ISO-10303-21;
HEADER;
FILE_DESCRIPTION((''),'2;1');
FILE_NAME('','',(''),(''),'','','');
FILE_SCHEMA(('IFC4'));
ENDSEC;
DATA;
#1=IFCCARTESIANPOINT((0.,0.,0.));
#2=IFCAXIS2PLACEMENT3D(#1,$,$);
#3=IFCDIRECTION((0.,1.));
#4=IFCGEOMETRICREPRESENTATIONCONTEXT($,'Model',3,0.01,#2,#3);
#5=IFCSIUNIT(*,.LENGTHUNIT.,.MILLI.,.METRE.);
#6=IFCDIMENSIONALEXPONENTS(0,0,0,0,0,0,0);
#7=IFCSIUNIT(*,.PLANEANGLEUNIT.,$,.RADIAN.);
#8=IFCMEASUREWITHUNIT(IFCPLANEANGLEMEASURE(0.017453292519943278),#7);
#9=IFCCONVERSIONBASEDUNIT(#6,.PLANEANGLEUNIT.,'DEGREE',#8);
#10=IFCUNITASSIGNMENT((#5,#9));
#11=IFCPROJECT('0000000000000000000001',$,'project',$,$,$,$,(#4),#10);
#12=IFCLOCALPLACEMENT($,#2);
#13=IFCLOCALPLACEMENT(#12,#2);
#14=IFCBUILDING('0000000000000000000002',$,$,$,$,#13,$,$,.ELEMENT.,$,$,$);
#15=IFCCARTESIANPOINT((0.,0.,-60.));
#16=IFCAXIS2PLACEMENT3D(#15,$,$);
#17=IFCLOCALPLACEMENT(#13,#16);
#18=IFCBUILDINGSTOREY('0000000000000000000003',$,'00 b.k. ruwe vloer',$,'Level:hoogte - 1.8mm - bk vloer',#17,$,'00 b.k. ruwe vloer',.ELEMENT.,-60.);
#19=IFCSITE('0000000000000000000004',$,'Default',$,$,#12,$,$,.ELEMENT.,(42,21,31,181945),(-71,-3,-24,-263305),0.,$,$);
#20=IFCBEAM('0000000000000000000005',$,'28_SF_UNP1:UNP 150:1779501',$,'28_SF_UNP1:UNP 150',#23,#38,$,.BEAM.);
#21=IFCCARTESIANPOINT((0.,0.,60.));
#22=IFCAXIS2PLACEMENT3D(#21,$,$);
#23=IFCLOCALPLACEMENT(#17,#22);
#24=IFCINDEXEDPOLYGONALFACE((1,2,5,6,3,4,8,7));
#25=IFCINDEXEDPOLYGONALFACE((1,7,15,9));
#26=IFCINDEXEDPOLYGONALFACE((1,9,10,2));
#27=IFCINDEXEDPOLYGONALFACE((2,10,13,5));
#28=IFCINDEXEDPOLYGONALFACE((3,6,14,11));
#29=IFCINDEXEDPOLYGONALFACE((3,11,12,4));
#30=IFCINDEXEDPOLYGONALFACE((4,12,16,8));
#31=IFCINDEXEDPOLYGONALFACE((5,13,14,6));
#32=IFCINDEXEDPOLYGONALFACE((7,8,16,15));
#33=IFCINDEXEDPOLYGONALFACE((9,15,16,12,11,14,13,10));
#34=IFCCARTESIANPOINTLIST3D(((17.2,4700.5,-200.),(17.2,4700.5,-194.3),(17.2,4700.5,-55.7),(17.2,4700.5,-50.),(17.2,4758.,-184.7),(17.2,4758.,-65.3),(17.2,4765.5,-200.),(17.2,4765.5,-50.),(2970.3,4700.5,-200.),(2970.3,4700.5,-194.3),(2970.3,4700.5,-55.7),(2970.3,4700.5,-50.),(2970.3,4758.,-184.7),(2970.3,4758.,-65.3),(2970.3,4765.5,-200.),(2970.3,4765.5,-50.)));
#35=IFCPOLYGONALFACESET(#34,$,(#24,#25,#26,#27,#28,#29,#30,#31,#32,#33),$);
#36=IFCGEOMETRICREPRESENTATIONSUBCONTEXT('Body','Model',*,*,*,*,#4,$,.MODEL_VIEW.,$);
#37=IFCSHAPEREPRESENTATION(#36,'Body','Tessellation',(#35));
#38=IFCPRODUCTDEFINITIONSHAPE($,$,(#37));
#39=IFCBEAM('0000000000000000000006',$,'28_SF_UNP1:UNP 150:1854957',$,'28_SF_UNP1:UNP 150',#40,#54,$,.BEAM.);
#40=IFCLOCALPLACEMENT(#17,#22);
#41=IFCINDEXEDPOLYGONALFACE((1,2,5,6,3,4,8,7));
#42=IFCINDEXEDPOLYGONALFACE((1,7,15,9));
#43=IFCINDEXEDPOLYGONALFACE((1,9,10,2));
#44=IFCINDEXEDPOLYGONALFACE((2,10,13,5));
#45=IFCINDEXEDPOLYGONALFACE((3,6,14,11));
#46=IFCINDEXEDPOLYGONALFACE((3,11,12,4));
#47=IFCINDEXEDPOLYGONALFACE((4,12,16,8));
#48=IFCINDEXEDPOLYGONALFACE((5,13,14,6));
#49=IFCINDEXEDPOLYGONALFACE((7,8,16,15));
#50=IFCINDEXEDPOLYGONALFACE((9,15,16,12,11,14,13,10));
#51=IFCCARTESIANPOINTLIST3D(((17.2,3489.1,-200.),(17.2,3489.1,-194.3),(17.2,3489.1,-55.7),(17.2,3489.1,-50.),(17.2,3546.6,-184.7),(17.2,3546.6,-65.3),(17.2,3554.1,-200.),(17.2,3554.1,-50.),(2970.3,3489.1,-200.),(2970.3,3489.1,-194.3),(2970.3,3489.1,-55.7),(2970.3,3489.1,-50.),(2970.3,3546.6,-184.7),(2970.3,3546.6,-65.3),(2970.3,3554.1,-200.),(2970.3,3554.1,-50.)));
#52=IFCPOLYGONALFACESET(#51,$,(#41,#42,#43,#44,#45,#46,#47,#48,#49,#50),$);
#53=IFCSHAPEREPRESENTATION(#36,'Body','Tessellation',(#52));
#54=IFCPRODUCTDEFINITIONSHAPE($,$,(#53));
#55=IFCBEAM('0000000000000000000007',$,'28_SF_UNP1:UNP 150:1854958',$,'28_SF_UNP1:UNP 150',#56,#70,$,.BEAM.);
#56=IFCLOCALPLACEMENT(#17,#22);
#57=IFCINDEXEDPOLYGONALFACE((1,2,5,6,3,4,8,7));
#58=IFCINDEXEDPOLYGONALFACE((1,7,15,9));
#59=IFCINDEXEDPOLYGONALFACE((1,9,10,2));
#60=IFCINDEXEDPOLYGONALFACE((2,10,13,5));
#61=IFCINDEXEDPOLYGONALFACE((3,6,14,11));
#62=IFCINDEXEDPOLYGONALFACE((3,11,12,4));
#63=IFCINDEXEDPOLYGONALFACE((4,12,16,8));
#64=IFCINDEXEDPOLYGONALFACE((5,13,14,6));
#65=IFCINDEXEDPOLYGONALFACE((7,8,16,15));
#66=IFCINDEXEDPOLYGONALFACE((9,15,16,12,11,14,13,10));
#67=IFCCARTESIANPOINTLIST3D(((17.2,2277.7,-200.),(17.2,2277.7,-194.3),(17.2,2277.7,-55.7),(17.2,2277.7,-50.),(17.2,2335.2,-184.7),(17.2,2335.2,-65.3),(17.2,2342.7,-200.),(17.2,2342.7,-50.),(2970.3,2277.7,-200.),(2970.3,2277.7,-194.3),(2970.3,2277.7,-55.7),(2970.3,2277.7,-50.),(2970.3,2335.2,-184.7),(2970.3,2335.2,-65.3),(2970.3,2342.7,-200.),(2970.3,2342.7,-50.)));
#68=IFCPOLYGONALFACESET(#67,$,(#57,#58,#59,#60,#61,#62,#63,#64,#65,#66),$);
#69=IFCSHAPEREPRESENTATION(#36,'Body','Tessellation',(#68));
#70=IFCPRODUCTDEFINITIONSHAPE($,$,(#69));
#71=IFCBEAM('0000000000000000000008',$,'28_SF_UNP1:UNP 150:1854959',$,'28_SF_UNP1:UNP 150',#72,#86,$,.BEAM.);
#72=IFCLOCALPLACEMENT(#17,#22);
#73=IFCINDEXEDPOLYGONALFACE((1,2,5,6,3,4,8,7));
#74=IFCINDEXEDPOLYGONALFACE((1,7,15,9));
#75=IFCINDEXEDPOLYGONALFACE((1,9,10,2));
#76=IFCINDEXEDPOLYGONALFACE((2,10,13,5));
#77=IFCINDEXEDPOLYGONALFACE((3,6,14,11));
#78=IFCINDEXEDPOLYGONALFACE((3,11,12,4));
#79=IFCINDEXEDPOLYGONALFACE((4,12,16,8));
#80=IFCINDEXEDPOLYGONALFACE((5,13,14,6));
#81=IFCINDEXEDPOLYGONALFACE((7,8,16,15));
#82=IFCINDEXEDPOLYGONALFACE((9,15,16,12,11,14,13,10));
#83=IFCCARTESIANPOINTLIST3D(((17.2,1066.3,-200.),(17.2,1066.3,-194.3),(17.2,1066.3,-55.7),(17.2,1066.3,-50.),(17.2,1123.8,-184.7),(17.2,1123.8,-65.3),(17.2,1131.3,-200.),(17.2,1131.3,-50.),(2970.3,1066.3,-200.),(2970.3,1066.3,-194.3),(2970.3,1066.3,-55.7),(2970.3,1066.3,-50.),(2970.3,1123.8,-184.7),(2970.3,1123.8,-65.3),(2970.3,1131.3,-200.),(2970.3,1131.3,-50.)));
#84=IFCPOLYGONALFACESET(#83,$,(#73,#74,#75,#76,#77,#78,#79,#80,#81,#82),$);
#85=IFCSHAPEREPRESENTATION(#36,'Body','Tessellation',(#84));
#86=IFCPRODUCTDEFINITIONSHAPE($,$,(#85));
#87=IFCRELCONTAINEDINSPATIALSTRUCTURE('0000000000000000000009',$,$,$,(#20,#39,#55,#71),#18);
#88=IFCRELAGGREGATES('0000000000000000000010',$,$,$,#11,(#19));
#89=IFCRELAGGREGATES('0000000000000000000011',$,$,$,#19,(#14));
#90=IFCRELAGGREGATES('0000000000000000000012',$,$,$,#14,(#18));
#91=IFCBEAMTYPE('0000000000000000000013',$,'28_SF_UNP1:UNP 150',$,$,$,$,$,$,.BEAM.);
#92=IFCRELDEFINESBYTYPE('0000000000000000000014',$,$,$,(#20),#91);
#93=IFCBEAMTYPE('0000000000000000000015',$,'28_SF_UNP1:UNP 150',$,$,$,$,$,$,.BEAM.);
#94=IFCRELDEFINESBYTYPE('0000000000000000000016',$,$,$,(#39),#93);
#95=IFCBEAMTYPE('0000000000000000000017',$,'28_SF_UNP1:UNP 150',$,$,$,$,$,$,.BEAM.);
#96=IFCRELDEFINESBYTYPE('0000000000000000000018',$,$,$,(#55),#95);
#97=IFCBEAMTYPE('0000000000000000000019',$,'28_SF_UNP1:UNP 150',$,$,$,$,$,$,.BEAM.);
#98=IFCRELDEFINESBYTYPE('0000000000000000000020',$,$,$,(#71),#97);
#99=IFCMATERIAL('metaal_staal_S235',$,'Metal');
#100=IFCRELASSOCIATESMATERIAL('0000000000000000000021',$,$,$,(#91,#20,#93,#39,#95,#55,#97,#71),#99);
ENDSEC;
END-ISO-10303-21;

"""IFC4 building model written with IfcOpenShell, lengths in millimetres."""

from ifc_helpers import new_model, entity, si_unit, converted_unit, direction, frame, origin, place, context, subcontext, project, spatial, indexed_curve, outline, extrude, source, transform, mapped, material, type_object, type_shapes, element, save


model = new_model("IFC4")

# Units and contexts
model_context = context("Model", 3, precision=0.01, world=origin(), true_north=direction((0.0, 1.0)))
body_context = subcontext(model_context, "Body", "Model", "MODEL_VIEW")
ifc_project = project(units=[si_unit("LENGTHUNIT", "METRE", prefix="MILLI"), converted_unit("PLANEANGLEUNIT", "DEGREE", entity("IfcPlaneAngleMeasure", 0.017453292519943278), si_unit("PLANEANGLEUNIT", "RADIAN"), dimensions=[0, 0, 0, 0, 0, 0, 0])], contexts=[model_context])

# Site, building, storey
site_placement = place(None, origin())
site = spatial("IfcSite", under=ifc_project, at=site_placement, Name="Default", CompositionType="ELEMENT", RefLatitude=(42, 21, 31, 181945), RefLongitude=(-71, -3, -24, -263305), RefElevation=0.0)
building_placement = place(site_placement, origin())
building = spatial("IfcBuilding", under=site, at=building_placement, CompositionType="ELEMENT")
storey_placement = place(building_placement, frame((0.0, 0.0, -60.0)))
storey = spatial("IfcBuildingStorey", under=building, at=storey_placement, Name="00 b.k. ruwe vloer", ObjectType="Level:hoogte - 1.8mm - bk vloer", LongName="00 b.k. ruwe vloer", CompositionType="ELEMENT", Elevation=-60.0)

# Beams
ifc_material = material(Name="metaal_staal_S235", Category="Metal")
beam_type_1 = type_object("IfcBeamType", Name="28_SF_UNP1:UNP 150", PredefinedType="BEAM", material=ifc_material)
shared_shape_1 = source(origin(), body_context, "Body", "SweptSolid", [
    extrude(outline(indexed_curve([(-75.0, -30.6), (-69.3, -30.6), (-59.7, 26.9), (59.7, 26.9), (69.3, -30.6), (75.0, -30.6), (75.0, 34.4), (-75.0, 34.4), (-75.0, -30.6)], self_intersect=False)), frame((17.2, 4731.2, -125.0), z_axis=(1.0, 0.0, 0.0), x_axis=(0.0, 0.0, -1.0)), (0.0, 0.0, 1.0), 2953.2),
])
type_shapes(beam_type_1, [shared_shape_1])
beam_1_placement = place(storey_placement, frame((0.0, 0.0, 60.0)))
element("IfcBeam", 1, at=beam_1_placement, inside=storey, type_object=beam_type_1, material=ifc_material, Name="28_SF_UNP1:UNP 150:1779501", ObjectType="28_SF_UNP1:UNP 150", PredefinedType="BEAM", context=body_context, shape_type="MappedRepresentation", body=[
    mapped(shared_shape_1, transform((0.0, 0.0, 0.0), scale=1.0)),
])
beam_type_2 = type_object("IfcBeamType", Name="28_SF_UNP1:UNP 150", PredefinedType="BEAM", material=ifc_material)
shared_shape_2 = source(origin(), body_context, "Body", "SweptSolid", [
    extrude(outline(indexed_curve([(-75.0, -30.6), (-69.3, -30.6), (-59.7, 26.9), (59.7, 26.9), (69.3, -30.6), (75.0, -30.6), (75.0, 34.4), (-75.0, 34.4), (-75.0, -30.6)], self_intersect=False)), frame((17.2, 3519.8, -125.0), z_axis=(1.0, 0.0, 0.0), x_axis=(0.0, 0.0, -1.0)), (0.0, 0.0, 1.0), 2953.2),
])
type_shapes(beam_type_2, [shared_shape_2])
beam_2_placement = place(storey_placement, frame((0.0, 0.0, 60.0)))
element("IfcBeam", 2, at=beam_2_placement, inside=storey, type_object=beam_type_2, material=ifc_material, Name="28_SF_UNP1:UNP 150:1854957", ObjectType="28_SF_UNP1:UNP 150", PredefinedType="BEAM", context=body_context, shape_type="MappedRepresentation", body=[
    mapped(shared_shape_2, transform((0.0, 0.0, 0.0), scale=1.0)),
])
beam_type_3 = type_object("IfcBeamType", Name="28_SF_UNP1:UNP 150", PredefinedType="BEAM", material=ifc_material)
shared_shape_3 = source(origin(), body_context, "Body", "SweptSolid", [
    extrude(outline(indexed_curve([(-75.0, -30.6), (-69.3, -30.6), (-59.7, 26.9), (59.7, 26.9), (69.3, -30.6), (75.0, -30.6), (75.0, 34.4), (-75.0, 34.4), (-75.0, -30.6)], self_intersect=False)), frame((17.2, 2308.4, -125.0), z_axis=(1.0, 0.0, 0.0), x_axis=(0.0, 0.0, -1.0)), (0.0, 0.0, 1.0), 2953.2),
])
type_shapes(beam_type_3, [shared_shape_3])
beam_3_placement = place(storey_placement, frame((0.0, 0.0, 60.0)))
element("IfcBeam", 3, at=beam_3_placement, inside=storey, type_object=beam_type_3, material=ifc_material, Name="28_SF_UNP1:UNP 150:1854958", ObjectType="28_SF_UNP1:UNP 150", PredefinedType="BEAM", context=body_context, shape_type="MappedRepresentation", body=[
    mapped(shared_shape_3, transform((0.0, 0.0, 0.0), scale=1.0)),
])
beam_type_4 = type_object("IfcBeamType", Name="28_SF_UNP1:UNP 150", PredefinedType="BEAM", material=ifc_material)
shared_shape_4 = source(origin(), body_context, "Body", "SweptSolid", [
    extrude(outline(indexed_curve([(-75.0, -30.6), (-69.3, -30.6), (-59.7, 26.9), (59.7, 26.9), (69.3, -30.6), (75.0, -30.6), (75.0, 34.4), (-75.0, 34.4), (-75.0, -30.6)], self_intersect=False)), frame((17.2, 1097.0, -125.0), z_axis=(1.0, 0.0, 0.0), x_axis=(0.0, 0.0, -1.0)), (0.0, 0.0, 1.0), 2953.2),
])
type_shapes(beam_type_4, [shared_shape_4])
beam_4_placement = place(storey_placement, frame((0.0, 0.0, 60.0)))
element("IfcBeam", 4, at=beam_4_placement, inside=storey, type_object=beam_type_4, material=ifc_material, Name="28_SF_UNP1:UNP 150:1854959", ObjectType="28_SF_UNP1:UNP 150", PredefinedType="BEAM", context=body_context, shape_type="MappedRepresentation", body=[
    mapped(shared_shape_4, transform((0.0, 0.0, 0.0), scale=1.0)),
])

save(model, "model.ifc")
